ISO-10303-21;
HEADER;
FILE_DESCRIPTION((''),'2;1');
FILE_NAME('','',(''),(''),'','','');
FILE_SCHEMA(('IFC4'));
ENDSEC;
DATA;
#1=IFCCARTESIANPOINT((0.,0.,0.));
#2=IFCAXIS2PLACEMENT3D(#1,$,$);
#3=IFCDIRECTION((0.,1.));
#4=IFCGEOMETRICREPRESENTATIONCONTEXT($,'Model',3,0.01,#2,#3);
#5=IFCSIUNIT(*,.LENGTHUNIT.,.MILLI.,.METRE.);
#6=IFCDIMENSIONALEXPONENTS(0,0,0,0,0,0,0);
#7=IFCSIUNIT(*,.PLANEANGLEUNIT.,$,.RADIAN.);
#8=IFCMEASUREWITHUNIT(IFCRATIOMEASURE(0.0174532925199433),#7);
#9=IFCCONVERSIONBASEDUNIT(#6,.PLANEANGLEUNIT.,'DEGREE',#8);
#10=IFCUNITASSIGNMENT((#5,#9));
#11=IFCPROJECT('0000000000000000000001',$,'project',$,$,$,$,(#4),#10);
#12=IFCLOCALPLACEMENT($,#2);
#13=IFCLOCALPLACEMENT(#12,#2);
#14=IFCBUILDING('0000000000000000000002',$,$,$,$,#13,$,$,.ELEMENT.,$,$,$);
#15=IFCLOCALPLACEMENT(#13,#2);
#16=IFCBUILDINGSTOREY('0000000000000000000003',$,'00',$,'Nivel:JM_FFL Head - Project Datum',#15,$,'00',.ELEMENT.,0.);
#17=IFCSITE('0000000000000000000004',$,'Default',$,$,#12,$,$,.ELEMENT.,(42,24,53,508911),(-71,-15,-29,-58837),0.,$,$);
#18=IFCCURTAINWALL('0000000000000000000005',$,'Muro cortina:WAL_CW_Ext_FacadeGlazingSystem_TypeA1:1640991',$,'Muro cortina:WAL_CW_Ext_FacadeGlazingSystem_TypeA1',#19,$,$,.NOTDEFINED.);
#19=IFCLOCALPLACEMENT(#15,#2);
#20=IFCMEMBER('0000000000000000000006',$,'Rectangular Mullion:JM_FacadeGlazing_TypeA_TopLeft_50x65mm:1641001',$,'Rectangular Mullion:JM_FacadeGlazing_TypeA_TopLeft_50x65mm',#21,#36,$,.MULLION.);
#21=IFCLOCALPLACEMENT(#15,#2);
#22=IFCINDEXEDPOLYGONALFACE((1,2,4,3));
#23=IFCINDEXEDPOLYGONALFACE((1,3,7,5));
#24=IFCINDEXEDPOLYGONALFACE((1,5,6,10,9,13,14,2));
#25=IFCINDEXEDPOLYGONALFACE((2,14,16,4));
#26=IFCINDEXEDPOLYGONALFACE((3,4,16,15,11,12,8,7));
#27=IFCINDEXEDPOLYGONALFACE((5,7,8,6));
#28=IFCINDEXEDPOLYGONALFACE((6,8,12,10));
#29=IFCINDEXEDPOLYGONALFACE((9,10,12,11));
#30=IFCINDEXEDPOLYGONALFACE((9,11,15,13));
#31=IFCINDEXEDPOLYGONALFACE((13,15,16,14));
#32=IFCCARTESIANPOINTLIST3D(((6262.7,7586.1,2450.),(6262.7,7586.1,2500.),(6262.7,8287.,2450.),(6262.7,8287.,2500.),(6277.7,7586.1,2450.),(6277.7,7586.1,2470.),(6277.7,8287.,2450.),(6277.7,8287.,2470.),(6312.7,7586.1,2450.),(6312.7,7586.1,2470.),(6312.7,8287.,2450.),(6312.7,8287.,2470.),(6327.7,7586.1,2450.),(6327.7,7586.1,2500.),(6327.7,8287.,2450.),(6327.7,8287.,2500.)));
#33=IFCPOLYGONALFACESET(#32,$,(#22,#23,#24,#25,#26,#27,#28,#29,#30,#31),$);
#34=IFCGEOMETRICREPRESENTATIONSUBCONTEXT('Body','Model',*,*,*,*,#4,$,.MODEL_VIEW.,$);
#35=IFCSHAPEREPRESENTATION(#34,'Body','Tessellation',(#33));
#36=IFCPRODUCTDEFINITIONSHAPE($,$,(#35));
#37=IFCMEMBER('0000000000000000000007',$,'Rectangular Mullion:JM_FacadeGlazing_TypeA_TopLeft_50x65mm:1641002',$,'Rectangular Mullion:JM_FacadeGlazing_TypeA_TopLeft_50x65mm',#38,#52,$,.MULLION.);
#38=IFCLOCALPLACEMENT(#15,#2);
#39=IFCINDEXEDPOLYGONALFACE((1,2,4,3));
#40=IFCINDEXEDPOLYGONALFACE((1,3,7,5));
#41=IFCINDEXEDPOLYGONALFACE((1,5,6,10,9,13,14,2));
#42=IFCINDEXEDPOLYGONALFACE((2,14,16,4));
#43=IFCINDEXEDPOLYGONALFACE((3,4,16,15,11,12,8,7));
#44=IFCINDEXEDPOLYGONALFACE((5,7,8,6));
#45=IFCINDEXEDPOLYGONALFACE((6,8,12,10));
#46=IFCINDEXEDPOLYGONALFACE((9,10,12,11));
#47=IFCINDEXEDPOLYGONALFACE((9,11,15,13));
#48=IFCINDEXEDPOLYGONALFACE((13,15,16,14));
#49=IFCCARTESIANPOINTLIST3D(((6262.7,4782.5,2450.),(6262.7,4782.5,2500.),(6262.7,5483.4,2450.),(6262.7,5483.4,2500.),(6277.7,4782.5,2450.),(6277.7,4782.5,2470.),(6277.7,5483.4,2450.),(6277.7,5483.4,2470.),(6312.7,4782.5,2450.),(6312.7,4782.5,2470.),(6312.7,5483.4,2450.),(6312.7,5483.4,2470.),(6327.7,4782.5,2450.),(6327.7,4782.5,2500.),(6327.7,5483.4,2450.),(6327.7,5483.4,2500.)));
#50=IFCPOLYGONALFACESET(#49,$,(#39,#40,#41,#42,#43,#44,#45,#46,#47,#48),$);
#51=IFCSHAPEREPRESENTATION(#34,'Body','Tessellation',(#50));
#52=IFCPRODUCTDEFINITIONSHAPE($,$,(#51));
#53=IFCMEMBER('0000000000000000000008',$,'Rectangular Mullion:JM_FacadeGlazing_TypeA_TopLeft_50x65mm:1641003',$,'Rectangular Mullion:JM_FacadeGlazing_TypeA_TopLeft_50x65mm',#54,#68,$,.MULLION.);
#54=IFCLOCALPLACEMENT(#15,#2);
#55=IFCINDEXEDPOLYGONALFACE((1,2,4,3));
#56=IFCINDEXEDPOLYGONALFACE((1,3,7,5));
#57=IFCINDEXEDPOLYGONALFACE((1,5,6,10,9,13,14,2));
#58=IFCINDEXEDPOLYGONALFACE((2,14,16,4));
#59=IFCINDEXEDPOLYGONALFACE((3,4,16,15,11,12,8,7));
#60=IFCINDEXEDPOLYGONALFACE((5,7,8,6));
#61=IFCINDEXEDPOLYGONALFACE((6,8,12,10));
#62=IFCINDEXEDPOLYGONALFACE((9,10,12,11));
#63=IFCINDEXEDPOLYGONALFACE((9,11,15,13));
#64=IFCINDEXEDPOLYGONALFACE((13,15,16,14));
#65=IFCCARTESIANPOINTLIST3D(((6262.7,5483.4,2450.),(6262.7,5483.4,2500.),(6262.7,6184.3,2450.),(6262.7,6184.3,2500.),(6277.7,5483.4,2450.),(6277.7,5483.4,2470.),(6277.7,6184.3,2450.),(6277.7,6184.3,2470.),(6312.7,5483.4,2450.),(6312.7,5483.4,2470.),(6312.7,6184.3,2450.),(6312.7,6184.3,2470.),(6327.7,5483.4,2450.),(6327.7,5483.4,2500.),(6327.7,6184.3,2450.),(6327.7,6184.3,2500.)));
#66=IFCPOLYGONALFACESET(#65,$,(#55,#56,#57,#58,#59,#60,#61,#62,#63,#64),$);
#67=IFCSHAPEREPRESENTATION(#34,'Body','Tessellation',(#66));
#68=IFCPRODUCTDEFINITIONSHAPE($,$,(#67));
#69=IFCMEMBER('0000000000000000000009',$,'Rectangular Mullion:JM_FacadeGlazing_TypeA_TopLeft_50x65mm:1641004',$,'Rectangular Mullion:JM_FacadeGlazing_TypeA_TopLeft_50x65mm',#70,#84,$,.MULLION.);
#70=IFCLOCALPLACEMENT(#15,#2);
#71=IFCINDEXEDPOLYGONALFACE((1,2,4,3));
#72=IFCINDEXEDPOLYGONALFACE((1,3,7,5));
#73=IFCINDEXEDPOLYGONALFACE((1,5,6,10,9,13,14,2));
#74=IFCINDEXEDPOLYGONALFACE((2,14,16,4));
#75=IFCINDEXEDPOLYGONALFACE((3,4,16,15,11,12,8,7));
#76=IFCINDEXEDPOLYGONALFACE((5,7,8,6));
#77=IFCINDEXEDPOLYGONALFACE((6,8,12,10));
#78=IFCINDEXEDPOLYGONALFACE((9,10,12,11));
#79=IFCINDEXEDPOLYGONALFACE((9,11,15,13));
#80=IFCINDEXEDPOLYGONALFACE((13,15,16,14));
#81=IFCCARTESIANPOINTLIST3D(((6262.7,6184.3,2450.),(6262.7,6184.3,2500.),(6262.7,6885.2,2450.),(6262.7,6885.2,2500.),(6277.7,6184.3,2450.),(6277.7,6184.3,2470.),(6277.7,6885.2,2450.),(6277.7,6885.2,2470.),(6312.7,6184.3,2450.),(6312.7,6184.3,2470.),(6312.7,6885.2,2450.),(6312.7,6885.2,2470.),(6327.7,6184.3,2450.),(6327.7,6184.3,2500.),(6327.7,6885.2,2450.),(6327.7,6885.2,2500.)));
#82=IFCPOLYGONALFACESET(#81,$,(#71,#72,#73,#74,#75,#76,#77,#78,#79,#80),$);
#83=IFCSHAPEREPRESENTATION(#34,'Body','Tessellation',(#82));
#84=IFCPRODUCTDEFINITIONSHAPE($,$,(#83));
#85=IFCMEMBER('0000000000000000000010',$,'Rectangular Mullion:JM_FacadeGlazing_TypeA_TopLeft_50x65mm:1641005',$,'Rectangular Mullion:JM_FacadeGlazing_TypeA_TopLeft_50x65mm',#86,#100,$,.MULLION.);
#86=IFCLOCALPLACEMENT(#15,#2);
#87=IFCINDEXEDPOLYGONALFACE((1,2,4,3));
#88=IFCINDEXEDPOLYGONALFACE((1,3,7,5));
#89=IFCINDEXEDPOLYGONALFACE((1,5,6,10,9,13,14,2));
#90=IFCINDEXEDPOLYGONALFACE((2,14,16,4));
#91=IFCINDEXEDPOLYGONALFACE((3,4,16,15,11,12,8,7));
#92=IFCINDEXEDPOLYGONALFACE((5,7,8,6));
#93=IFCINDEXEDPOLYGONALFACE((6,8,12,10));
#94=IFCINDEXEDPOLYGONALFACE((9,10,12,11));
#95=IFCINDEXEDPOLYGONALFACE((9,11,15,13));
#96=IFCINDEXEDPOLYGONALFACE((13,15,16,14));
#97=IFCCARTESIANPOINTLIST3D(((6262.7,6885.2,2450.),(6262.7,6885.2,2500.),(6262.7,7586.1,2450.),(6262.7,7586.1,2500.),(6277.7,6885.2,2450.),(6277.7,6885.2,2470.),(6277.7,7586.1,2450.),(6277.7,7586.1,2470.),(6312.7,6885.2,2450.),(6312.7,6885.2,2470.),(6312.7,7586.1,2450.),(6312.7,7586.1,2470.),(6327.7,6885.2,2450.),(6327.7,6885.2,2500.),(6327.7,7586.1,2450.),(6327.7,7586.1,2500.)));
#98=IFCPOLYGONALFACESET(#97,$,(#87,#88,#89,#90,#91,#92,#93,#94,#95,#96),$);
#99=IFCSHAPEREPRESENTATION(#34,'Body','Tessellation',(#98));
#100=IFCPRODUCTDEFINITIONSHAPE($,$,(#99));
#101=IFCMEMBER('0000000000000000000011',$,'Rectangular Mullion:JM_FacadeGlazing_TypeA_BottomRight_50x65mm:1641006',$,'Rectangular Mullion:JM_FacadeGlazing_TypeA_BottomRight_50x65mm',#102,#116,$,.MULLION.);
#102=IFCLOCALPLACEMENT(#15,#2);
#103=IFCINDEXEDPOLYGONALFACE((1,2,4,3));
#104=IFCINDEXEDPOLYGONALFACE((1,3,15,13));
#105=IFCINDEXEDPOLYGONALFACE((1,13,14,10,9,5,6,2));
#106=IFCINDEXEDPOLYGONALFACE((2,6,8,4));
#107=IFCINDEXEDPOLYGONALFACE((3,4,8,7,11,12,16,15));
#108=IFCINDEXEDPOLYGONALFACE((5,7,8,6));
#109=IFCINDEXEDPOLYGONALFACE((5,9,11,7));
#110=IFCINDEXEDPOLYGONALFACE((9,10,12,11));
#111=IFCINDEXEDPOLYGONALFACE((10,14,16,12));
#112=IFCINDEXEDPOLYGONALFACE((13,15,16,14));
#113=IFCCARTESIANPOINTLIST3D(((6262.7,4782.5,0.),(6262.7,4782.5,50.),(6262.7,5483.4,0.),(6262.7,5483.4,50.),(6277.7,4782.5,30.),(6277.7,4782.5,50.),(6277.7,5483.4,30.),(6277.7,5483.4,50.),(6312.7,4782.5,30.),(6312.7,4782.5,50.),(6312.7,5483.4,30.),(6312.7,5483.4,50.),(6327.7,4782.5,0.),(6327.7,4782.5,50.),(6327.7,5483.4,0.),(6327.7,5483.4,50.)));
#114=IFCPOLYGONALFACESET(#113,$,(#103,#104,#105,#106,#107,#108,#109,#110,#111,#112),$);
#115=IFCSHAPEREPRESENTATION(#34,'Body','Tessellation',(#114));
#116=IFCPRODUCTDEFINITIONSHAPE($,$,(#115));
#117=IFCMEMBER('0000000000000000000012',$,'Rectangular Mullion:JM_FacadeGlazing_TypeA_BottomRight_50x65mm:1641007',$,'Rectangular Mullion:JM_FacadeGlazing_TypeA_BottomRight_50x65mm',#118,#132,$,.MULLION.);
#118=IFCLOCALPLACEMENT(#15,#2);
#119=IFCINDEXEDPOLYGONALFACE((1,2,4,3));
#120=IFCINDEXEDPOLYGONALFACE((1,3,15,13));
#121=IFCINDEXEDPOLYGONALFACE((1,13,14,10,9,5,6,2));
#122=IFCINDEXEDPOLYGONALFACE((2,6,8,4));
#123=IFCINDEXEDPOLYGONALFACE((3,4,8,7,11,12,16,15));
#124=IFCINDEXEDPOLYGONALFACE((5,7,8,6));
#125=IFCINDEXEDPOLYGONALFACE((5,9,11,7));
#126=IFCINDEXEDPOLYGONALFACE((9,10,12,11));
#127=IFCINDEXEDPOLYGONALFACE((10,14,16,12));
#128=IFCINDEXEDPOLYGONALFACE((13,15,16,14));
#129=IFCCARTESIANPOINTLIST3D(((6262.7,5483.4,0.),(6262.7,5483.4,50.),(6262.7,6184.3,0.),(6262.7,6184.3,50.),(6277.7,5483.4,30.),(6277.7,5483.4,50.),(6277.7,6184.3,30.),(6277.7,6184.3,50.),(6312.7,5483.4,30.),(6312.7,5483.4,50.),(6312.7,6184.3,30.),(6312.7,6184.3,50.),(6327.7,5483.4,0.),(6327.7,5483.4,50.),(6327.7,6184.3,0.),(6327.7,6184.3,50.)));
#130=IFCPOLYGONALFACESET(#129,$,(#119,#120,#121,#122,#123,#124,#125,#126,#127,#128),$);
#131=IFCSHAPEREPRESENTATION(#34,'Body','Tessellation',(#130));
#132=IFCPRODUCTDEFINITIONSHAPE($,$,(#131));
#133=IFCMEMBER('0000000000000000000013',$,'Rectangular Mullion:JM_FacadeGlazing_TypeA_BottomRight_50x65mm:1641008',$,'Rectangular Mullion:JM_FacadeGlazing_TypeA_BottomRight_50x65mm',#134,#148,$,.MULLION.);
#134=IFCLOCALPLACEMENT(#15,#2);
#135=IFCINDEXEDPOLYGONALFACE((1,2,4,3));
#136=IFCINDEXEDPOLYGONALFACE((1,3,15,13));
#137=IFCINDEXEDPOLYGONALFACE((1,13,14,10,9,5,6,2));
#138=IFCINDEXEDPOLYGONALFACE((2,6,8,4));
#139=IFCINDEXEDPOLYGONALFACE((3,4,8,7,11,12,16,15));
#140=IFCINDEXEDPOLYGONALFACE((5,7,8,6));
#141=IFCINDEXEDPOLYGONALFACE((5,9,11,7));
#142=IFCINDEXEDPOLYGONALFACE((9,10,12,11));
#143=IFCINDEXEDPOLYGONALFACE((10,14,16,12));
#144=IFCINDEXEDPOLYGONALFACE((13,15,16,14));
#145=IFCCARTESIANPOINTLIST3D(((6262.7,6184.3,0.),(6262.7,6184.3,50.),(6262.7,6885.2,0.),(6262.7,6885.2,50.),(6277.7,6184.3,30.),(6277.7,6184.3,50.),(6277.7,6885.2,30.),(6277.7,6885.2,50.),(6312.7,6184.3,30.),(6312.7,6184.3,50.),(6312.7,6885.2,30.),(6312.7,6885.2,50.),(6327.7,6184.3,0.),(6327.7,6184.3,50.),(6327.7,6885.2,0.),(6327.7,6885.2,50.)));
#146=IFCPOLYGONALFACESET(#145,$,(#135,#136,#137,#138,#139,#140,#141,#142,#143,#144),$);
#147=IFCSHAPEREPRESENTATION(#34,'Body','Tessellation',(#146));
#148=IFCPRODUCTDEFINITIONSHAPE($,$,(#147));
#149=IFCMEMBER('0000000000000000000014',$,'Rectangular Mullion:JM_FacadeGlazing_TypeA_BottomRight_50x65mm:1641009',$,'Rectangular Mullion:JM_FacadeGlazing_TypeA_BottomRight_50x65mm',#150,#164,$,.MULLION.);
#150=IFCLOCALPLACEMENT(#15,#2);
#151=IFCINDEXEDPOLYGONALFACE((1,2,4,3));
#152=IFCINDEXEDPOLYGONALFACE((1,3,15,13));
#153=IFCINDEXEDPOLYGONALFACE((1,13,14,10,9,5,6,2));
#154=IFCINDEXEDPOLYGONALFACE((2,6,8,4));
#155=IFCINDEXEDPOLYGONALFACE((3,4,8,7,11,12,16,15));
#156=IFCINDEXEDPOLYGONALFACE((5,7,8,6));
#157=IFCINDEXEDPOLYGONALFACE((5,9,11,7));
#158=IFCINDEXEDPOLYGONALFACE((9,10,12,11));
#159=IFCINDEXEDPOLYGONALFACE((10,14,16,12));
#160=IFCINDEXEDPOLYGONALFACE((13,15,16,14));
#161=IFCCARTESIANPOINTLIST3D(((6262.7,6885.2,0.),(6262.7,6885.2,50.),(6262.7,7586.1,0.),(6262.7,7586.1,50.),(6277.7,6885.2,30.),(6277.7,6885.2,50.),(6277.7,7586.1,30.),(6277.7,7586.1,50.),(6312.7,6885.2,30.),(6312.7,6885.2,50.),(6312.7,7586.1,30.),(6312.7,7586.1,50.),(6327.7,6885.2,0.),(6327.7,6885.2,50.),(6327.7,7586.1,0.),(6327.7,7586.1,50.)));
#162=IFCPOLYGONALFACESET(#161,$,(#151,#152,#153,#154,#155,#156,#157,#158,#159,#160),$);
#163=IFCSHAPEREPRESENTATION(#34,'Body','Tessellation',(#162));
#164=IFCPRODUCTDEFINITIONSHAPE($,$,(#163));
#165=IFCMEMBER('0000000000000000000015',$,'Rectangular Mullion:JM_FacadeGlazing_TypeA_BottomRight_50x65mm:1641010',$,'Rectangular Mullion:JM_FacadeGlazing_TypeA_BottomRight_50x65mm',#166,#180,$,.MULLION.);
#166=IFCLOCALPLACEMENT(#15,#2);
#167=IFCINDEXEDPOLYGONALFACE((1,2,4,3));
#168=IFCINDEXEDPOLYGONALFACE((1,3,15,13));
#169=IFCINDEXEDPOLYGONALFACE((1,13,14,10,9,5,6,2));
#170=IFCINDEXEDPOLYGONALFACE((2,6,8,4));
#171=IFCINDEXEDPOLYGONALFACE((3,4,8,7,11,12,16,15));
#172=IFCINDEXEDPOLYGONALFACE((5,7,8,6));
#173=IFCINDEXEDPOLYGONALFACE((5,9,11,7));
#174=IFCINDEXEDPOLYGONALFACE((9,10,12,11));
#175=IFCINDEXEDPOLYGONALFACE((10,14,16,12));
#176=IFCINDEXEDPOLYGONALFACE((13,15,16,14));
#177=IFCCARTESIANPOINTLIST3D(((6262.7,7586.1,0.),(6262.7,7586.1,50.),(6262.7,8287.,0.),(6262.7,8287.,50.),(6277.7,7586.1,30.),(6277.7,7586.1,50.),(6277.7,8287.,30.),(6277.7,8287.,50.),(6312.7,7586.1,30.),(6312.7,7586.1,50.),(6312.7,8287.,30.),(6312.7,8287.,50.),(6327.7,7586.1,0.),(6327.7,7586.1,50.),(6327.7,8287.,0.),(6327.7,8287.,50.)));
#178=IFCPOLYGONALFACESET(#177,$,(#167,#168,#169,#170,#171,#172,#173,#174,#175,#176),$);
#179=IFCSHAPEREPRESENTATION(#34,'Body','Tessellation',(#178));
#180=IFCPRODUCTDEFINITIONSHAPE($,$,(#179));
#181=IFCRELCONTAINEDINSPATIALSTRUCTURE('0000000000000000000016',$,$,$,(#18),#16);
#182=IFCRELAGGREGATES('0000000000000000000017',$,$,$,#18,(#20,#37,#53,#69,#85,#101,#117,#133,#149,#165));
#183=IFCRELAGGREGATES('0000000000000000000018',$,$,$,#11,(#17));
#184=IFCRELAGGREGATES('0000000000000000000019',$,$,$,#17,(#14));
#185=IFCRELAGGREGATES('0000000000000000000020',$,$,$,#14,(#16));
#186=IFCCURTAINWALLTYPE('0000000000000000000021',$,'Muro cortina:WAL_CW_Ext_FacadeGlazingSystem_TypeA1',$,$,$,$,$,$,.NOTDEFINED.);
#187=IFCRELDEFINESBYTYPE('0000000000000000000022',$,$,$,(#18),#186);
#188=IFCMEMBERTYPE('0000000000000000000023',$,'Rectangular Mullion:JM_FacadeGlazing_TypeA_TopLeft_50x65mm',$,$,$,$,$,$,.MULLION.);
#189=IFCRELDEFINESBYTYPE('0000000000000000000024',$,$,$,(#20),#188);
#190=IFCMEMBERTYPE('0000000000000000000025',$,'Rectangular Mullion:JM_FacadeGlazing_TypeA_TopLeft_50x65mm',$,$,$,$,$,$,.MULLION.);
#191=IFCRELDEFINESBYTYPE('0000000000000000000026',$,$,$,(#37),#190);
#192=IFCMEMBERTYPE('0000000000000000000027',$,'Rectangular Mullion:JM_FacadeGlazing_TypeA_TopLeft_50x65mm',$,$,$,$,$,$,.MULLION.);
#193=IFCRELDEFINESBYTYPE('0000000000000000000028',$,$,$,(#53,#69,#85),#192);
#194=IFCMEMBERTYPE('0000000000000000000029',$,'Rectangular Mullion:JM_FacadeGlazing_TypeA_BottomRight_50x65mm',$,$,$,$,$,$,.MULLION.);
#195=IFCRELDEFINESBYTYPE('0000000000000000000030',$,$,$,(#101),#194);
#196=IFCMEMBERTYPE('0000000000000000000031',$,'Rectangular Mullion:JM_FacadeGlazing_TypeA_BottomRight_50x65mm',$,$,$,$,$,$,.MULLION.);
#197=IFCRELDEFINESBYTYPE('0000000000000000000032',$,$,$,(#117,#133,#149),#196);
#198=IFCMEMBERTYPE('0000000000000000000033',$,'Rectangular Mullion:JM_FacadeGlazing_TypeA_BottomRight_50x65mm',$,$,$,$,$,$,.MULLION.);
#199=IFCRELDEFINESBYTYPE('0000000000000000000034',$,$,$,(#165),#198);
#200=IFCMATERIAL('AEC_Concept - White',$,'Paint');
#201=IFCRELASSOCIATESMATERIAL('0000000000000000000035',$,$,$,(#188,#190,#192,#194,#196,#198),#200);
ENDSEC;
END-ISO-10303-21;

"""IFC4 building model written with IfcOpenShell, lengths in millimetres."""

from ifc_helpers import new_model, entity, si_unit, converted_unit, direction, frame, origin, place, context, subcontext, project, spatial, indexed_curve, outline, extrude, source, transform, mapped, material, type_object, type_shapes, element, aggregate, save


model = new_model("IFC4")

# Units and contexts
model_context = context("Model", 3, precision=0.01, world=origin(), true_north=direction((0.0, 1.0)))
body_context = subcontext(model_context, "Body", "Model", "MODEL_VIEW")
ifc_project = project(units=[si_unit("LENGTHUNIT", "METRE", prefix="MILLI"), converted_unit("PLANEANGLEUNIT", "DEGREE", entity("IfcRatioMeasure", 0.0174532925199433), si_unit("PLANEANGLEUNIT", "RADIAN"), dimensions=[0, 0, 0, 0, 0, 0, 0])], contexts=[model_context])

# Site, building, storey
site_placement = place(None, origin())
site = spatial("IfcSite", under=ifc_project, at=site_placement, Name="Default", CompositionType="ELEMENT", RefLatitude=(42, 24, 53, 508911), RefLongitude=(-71, -15, -29, -58837), RefElevation=0.0)
building_placement = place(site_placement, origin())
building = spatial("IfcBuilding", under=site, at=building_placement, CompositionType="ELEMENT")
storey_placement = place(building_placement, origin())
storey = spatial("IfcBuildingStorey", under=building, at=storey_placement, Name="00", ObjectType="Nivel:JM_FFL Head - Project Datum", LongName="00", CompositionType="ELEMENT", Elevation=0.0)

# Curtain wall, members
curtain_wall_type = type_object("IfcCurtainWallType", Name="Muro cortina:WAL_CW_Ext_FacadeGlazingSystem_TypeA1", PredefinedType="NOTDEFINED")
curtain_wall_placement = place(storey_placement, origin())
curtain_wall = element("IfcCurtainWall", 1, at=curtain_wall_placement, inside=storey, type_object=curtain_wall_type, Name="Muro cortina:WAL_CW_Ext_FacadeGlazingSystem_TypeA1:1640991", ObjectType="Muro cortina:WAL_CW_Ext_FacadeGlazingSystem_TypeA1", PredefinedType="NOTDEFINED")
ifc_material_1 = material(Name="AEC_Concept - White", Category="Paint")
member_type_1 = type_object("IfcMemberType", Name="Rectangular Mullion:JM_FacadeGlazing_TypeA_TopLeft_50x65mm", PredefinedType="MULLION", material=ifc_material_1)
shared_shape_1 = source(origin(), body_context, "Body", "SweptSolid", [
    extrude(outline(indexed_curve([(-32.5, -17.5), (-17.5, -17.5), (-17.5, 2.5), (17.5, 2.5), (17.5, -17.5), (32.5, -17.5), (32.5, 32.5), (-32.5, 32.5), (-32.5, -17.5)], self_intersect=False)), frame((-32.5, 32.5, -700.9), z_axis=(0.0, 0.0, 1.0), x_axis=(0.0, -1.0, 0.0)), (0.0, 0.0, 1.0), 700.9),
])
type_shapes(member_type_1, [shared_shape_1])
member_1_placement = place(curtain_wall_placement, frame((6262.7, 8287.0, 2500.0), z_axis=(0.0, 1.0, 0.0), x_axis=(0.0, 0.0, 1.0)))
member_1 = element("IfcMember", 2, at=member_1_placement, type_object=member_type_1, Name="Rectangular Mullion:JM_FacadeGlazing_TypeA_TopLeft_50x65mm:1641001", ObjectType="Rectangular Mullion:JM_FacadeGlazing_TypeA_TopLeft_50x65mm", PredefinedType="MULLION", context=body_context, shape_type="MappedRepresentation", body=[
    mapped(shared_shape_1, transform((0.0, 0.0, 0.0), scale=1.0)),
])
member_type_2 = type_object("IfcMemberType", Name="Rectangular Mullion:JM_FacadeGlazing_TypeA_TopLeft_50x65mm", PredefinedType="MULLION", material=ifc_material_1)
shared_shape_2 = source(origin(), body_context, "Body", "SweptSolid", [
    extrude(outline(indexed_curve([(-32.5, -17.5), (-17.5, -17.5), (-17.5, 2.5), (17.5, 2.5), (17.5, -17.5), (32.5, -17.5), (32.5, 32.5), (-32.5, 32.5), (-32.5, -17.5)], self_intersect=False)), frame((-32.5, 32.5, -700.9), z_axis=(0.0, 0.0, 1.0), x_axis=(0.0, -1.0, 0.0)), (0.0, 0.0, 1.0), 700.9),
])
type_shapes(member_type_2, [shared_shape_2])
member_2_placement = place(curtain_wall_placement, frame((6262.7, 5483.4, 2500.0), z_axis=(0.0, 1.0, 0.0), x_axis=(0.0, 0.0, 1.0)))
member_2 = element("IfcMember", 3, at=member_2_placement, type_object=member_type_2, Name="Rectangular Mullion:JM_FacadeGlazing_TypeA_TopLeft_50x65mm:1641002", ObjectType="Rectangular Mullion:JM_FacadeGlazing_TypeA_TopLeft_50x65mm", PredefinedType="MULLION", context=body_context, shape_type="MappedRepresentation", body=[
    mapped(shared_shape_2, transform((0.0, 0.0, 0.0), scale=1.0)),
])
member_type_3 = type_object("IfcMemberType", Name="Rectangular Mullion:JM_FacadeGlazing_TypeA_TopLeft_50x65mm", PredefinedType="MULLION", material=ifc_material_1)
shared_shape_3 = source(origin(), body_context, "Body", "SweptSolid", [
    extrude(outline(indexed_curve([(-32.5, -17.5), (-17.5, -17.5), (-17.5, 2.5), (17.5, 2.5), (17.5, -17.5), (32.5, -17.5), (32.5, 32.5), (-32.5, 32.5), (-32.5, -17.5)], self_intersect=False)), frame((-32.5, 32.5, -700.9), z_axis=(0.0, 0.0, 1.0), x_axis=(0.0, -1.0, 0.0)), (0.0, 0.0, 1.0), 700.9),
])
type_shapes(member_type_3, [shared_shape_3])
member_3_placement = place(curtain_wall_placement, frame((6262.7, 6184.3, 2500.0), z_axis=(0.0, 1.0, 0.0), x_axis=(0.0, 0.0, 1.0)))
member_3 = element("IfcMember", 4, at=member_3_placement, type_object=member_type_3, Name="Rectangular Mullion:JM_FacadeGlazing_TypeA_TopLeft_50x65mm:1641003", ObjectType="Rectangular Mullion:JM_FacadeGlazing_TypeA_TopLeft_50x65mm", PredefinedType="MULLION", context=body_context, shape_type="MappedRepresentation", body=[
    mapped(shared_shape_3, transform((0.0, 0.0, 0.0), scale=1.0)),
])
member_4_placement = place(curtain_wall_placement, frame((6262.7, 6885.2, 2500.0), z_axis=(0.0, 1.0, 0.0), x_axis=(0.0, 0.0, 1.0)))
member_4 = element("IfcMember", 5, at=member_4_placement, type_object=member_type_3, Name="Rectangular Mullion:JM_FacadeGlazing_TypeA_TopLeft_50x65mm:1641004", ObjectType="Rectangular Mullion:JM_FacadeGlazing_TypeA_TopLeft_50x65mm", PredefinedType="MULLION", context=body_context, shape_type="MappedRepresentation", body=[
    mapped(shared_shape_3, transform((0.0, 0.0, 0.0), scale=1.0)),
])
member_5_placement = place(curtain_wall_placement, frame((6262.7, 7586.1, 2500.0), z_axis=(0.0, 1.0, 0.0), x_axis=(0.0, 0.0, 1.0)))
member_5 = element("IfcMember", 6, at=member_5_placement, type_object=member_type_3, Name="Rectangular Mullion:JM_FacadeGlazing_TypeA_TopLeft_50x65mm:1641005", ObjectType="Rectangular Mullion:JM_FacadeGlazing_TypeA_TopLeft_50x65mm", PredefinedType="MULLION", context=body_context, shape_type="MappedRepresentation", body=[
    mapped(shared_shape_3, transform((0.0, 0.0, 0.0), scale=1.0)),
])
member_type_4 = type_object("IfcMemberType", Name="Rectangular Mullion:JM_FacadeGlazing_TypeA_BottomRight_50x65mm", PredefinedType="MULLION", material=ifc_material_1)
shared_shape_4 = source(origin(), body_context, "Body", "SweptSolid", [
    extrude(outline(indexed_curve([(-32.5, -17.5), (-17.5, -17.5), (-17.5, 2.5), (17.5, 2.5), (17.5, -17.5), (32.5, -17.5), (32.5, 32.5), (-32.5, 32.5), (-32.5, -17.5)], self_intersect=False)), frame((-32.5, 32.5, -700.9), z_axis=(0.0, 0.0, 1.0), x_axis=(0.0, -1.0, 0.0)), (0.0, 0.0, 1.0), 700.9),
])
type_shapes(member_type_4, [shared_shape_4])
member_6_placement = place(curtain_wall_placement, frame((6262.7, 4782.5, 0.0), z_axis=(0.0, -1.0, 0.0), x_axis=(0.0, 0.0, -1.0)))
member_6 = element("IfcMember", 7, at=member_6_placement, type_object=member_type_4, Name="Rectangular Mullion:JM_FacadeGlazing_TypeA_BottomRight_50x65mm:1641006", ObjectType="Rectangular Mullion:JM_FacadeGlazing_TypeA_BottomRight_50x65mm", PredefinedType="MULLION", context=body_context, shape_type="MappedRepresentation", body=[
    mapped(shared_shape_4, transform((0.0, 0.0, 0.0), scale=1.0)),
])
member_type_5 = type_object("IfcMemberType", Name="Rectangular Mullion:JM_FacadeGlazing_TypeA_BottomRight_50x65mm", PredefinedType="MULLION", material=ifc_material_1)
shared_shape_5 = source(origin(), body_context, "Body", "SweptSolid", [
    extrude(outline(indexed_curve([(-32.5, -17.5), (-17.5, -17.5), (-17.5, 2.5), (17.5, 2.5), (17.5, -17.5), (32.5, -17.5), (32.5, 32.5), (-32.5, 32.5), (-32.5, -17.5)], self_intersect=False)), frame((-32.5, 32.5, -700.9), z_axis=(0.0, 0.0, 1.0), x_axis=(0.0, -1.0, 0.0)), (0.0, 0.0, 1.0), 700.9),
])
type_shapes(member_type_5, [shared_shape_5])
member_7_placement = place(curtain_wall_placement, frame((6262.7, 5483.4, 0.0), z_axis=(0.0, -1.0, 0.0), x_axis=(0.0, 0.0, -1.0)))
member_7 = element("IfcMember", 8, at=member_7_placement, type_object=member_type_5, Name="Rectangular Mullion:JM_FacadeGlazing_TypeA_BottomRight_50x65mm:1641007", ObjectType="Rectangular Mullion:JM_FacadeGlazing_TypeA_BottomRight_50x65mm", PredefinedType="MULLION", context=body_context, shape_type="MappedRepresentation", body=[
    mapped(shared_shape_5, transform((0.0, 0.0, 0.0), scale=1.0)),
])
member_8_placement = place(curtain_wall_placement, frame((6262.7, 6184.3, 0.0), z_axis=(0.0, -1.0, 0.0), x_axis=(0.0, 0.0, -1.0)))
member_8 = element("IfcMember", 9, at=member_8_placement, type_object=member_type_5, Name="Rectangular Mullion:JM_FacadeGlazing_TypeA_BottomRight_50x65mm:1641008", ObjectType="Rectangular Mullion:JM_FacadeGlazing_TypeA_BottomRight_50x65mm", PredefinedType="MULLION", context=body_context, shape_type="MappedRepresentation", body=[
    mapped(shared_shape_5, transform((0.0, 0.0, 0.0), scale=1.0)),
])
member_9_placement = place(curtain_wall_placement, frame((6262.7, 6885.2, 0.0), z_axis=(0.0, -1.0, 0.0), x_axis=(0.0, 0.0, -1.0)))
member_9 = element("IfcMember", 10, at=member_9_placement, type_object=member_type_5, Name="Rectangular Mullion:JM_FacadeGlazing_TypeA_BottomRight_50x65mm:1641009", ObjectType="Rectangular Mullion:JM_FacadeGlazing_TypeA_BottomRight_50x65mm", PredefinedType="MULLION", context=body_context, shape_type="MappedRepresentation", body=[
    mapped(shared_shape_5, transform((0.0, 0.0, 0.0), scale=1.0)),
])
member_type_6 = type_object("IfcMemberType", Name="Rectangular Mullion:JM_FacadeGlazing_TypeA_BottomRight_50x65mm", PredefinedType="MULLION", material=ifc_material_1)
shared_shape_6 = source(origin(), body_context, "Body", "SweptSolid", [
    extrude(outline(indexed_curve([(-32.5, -17.5), (-17.5, -17.5), (-17.5, 2.5), (17.5, 2.5), (17.5, -17.5), (32.5, -17.5), (32.5, 32.5), (-32.5, 32.5), (-32.5, -17.5)], self_intersect=False)), frame((-32.5, 32.5, -700.9), z_axis=(0.0, 0.0, 1.0), x_axis=(0.0, -1.0, 0.0)), (0.0, 0.0, 1.0), 700.9),
])
type_shapes(member_type_6, [shared_shape_6])
member_10_placement = place(curtain_wall_placement, frame((6262.7, 7586.1, 0.0), z_axis=(0.0, -1.0, 0.0), x_axis=(0.0, 0.0, -1.0)))
member_10 = element("IfcMember", 11, at=member_10_placement, type_object=member_type_6, Name="Rectangular Mullion:JM_FacadeGlazing_TypeA_BottomRight_50x65mm:1641010", ObjectType="Rectangular Mullion:JM_FacadeGlazing_TypeA_BottomRight_50x65mm", PredefinedType="MULLION", context=body_context, shape_type="MappedRepresentation", body=[
    mapped(shared_shape_6, transform((0.0, 0.0, 0.0), scale=1.0)),
])
aggregate(curtain_wall, [member_1, member_2, member_3, member_4, member_5, member_6, member_7, member_8, member_9, member_10])

save(model, "model.ifc")
